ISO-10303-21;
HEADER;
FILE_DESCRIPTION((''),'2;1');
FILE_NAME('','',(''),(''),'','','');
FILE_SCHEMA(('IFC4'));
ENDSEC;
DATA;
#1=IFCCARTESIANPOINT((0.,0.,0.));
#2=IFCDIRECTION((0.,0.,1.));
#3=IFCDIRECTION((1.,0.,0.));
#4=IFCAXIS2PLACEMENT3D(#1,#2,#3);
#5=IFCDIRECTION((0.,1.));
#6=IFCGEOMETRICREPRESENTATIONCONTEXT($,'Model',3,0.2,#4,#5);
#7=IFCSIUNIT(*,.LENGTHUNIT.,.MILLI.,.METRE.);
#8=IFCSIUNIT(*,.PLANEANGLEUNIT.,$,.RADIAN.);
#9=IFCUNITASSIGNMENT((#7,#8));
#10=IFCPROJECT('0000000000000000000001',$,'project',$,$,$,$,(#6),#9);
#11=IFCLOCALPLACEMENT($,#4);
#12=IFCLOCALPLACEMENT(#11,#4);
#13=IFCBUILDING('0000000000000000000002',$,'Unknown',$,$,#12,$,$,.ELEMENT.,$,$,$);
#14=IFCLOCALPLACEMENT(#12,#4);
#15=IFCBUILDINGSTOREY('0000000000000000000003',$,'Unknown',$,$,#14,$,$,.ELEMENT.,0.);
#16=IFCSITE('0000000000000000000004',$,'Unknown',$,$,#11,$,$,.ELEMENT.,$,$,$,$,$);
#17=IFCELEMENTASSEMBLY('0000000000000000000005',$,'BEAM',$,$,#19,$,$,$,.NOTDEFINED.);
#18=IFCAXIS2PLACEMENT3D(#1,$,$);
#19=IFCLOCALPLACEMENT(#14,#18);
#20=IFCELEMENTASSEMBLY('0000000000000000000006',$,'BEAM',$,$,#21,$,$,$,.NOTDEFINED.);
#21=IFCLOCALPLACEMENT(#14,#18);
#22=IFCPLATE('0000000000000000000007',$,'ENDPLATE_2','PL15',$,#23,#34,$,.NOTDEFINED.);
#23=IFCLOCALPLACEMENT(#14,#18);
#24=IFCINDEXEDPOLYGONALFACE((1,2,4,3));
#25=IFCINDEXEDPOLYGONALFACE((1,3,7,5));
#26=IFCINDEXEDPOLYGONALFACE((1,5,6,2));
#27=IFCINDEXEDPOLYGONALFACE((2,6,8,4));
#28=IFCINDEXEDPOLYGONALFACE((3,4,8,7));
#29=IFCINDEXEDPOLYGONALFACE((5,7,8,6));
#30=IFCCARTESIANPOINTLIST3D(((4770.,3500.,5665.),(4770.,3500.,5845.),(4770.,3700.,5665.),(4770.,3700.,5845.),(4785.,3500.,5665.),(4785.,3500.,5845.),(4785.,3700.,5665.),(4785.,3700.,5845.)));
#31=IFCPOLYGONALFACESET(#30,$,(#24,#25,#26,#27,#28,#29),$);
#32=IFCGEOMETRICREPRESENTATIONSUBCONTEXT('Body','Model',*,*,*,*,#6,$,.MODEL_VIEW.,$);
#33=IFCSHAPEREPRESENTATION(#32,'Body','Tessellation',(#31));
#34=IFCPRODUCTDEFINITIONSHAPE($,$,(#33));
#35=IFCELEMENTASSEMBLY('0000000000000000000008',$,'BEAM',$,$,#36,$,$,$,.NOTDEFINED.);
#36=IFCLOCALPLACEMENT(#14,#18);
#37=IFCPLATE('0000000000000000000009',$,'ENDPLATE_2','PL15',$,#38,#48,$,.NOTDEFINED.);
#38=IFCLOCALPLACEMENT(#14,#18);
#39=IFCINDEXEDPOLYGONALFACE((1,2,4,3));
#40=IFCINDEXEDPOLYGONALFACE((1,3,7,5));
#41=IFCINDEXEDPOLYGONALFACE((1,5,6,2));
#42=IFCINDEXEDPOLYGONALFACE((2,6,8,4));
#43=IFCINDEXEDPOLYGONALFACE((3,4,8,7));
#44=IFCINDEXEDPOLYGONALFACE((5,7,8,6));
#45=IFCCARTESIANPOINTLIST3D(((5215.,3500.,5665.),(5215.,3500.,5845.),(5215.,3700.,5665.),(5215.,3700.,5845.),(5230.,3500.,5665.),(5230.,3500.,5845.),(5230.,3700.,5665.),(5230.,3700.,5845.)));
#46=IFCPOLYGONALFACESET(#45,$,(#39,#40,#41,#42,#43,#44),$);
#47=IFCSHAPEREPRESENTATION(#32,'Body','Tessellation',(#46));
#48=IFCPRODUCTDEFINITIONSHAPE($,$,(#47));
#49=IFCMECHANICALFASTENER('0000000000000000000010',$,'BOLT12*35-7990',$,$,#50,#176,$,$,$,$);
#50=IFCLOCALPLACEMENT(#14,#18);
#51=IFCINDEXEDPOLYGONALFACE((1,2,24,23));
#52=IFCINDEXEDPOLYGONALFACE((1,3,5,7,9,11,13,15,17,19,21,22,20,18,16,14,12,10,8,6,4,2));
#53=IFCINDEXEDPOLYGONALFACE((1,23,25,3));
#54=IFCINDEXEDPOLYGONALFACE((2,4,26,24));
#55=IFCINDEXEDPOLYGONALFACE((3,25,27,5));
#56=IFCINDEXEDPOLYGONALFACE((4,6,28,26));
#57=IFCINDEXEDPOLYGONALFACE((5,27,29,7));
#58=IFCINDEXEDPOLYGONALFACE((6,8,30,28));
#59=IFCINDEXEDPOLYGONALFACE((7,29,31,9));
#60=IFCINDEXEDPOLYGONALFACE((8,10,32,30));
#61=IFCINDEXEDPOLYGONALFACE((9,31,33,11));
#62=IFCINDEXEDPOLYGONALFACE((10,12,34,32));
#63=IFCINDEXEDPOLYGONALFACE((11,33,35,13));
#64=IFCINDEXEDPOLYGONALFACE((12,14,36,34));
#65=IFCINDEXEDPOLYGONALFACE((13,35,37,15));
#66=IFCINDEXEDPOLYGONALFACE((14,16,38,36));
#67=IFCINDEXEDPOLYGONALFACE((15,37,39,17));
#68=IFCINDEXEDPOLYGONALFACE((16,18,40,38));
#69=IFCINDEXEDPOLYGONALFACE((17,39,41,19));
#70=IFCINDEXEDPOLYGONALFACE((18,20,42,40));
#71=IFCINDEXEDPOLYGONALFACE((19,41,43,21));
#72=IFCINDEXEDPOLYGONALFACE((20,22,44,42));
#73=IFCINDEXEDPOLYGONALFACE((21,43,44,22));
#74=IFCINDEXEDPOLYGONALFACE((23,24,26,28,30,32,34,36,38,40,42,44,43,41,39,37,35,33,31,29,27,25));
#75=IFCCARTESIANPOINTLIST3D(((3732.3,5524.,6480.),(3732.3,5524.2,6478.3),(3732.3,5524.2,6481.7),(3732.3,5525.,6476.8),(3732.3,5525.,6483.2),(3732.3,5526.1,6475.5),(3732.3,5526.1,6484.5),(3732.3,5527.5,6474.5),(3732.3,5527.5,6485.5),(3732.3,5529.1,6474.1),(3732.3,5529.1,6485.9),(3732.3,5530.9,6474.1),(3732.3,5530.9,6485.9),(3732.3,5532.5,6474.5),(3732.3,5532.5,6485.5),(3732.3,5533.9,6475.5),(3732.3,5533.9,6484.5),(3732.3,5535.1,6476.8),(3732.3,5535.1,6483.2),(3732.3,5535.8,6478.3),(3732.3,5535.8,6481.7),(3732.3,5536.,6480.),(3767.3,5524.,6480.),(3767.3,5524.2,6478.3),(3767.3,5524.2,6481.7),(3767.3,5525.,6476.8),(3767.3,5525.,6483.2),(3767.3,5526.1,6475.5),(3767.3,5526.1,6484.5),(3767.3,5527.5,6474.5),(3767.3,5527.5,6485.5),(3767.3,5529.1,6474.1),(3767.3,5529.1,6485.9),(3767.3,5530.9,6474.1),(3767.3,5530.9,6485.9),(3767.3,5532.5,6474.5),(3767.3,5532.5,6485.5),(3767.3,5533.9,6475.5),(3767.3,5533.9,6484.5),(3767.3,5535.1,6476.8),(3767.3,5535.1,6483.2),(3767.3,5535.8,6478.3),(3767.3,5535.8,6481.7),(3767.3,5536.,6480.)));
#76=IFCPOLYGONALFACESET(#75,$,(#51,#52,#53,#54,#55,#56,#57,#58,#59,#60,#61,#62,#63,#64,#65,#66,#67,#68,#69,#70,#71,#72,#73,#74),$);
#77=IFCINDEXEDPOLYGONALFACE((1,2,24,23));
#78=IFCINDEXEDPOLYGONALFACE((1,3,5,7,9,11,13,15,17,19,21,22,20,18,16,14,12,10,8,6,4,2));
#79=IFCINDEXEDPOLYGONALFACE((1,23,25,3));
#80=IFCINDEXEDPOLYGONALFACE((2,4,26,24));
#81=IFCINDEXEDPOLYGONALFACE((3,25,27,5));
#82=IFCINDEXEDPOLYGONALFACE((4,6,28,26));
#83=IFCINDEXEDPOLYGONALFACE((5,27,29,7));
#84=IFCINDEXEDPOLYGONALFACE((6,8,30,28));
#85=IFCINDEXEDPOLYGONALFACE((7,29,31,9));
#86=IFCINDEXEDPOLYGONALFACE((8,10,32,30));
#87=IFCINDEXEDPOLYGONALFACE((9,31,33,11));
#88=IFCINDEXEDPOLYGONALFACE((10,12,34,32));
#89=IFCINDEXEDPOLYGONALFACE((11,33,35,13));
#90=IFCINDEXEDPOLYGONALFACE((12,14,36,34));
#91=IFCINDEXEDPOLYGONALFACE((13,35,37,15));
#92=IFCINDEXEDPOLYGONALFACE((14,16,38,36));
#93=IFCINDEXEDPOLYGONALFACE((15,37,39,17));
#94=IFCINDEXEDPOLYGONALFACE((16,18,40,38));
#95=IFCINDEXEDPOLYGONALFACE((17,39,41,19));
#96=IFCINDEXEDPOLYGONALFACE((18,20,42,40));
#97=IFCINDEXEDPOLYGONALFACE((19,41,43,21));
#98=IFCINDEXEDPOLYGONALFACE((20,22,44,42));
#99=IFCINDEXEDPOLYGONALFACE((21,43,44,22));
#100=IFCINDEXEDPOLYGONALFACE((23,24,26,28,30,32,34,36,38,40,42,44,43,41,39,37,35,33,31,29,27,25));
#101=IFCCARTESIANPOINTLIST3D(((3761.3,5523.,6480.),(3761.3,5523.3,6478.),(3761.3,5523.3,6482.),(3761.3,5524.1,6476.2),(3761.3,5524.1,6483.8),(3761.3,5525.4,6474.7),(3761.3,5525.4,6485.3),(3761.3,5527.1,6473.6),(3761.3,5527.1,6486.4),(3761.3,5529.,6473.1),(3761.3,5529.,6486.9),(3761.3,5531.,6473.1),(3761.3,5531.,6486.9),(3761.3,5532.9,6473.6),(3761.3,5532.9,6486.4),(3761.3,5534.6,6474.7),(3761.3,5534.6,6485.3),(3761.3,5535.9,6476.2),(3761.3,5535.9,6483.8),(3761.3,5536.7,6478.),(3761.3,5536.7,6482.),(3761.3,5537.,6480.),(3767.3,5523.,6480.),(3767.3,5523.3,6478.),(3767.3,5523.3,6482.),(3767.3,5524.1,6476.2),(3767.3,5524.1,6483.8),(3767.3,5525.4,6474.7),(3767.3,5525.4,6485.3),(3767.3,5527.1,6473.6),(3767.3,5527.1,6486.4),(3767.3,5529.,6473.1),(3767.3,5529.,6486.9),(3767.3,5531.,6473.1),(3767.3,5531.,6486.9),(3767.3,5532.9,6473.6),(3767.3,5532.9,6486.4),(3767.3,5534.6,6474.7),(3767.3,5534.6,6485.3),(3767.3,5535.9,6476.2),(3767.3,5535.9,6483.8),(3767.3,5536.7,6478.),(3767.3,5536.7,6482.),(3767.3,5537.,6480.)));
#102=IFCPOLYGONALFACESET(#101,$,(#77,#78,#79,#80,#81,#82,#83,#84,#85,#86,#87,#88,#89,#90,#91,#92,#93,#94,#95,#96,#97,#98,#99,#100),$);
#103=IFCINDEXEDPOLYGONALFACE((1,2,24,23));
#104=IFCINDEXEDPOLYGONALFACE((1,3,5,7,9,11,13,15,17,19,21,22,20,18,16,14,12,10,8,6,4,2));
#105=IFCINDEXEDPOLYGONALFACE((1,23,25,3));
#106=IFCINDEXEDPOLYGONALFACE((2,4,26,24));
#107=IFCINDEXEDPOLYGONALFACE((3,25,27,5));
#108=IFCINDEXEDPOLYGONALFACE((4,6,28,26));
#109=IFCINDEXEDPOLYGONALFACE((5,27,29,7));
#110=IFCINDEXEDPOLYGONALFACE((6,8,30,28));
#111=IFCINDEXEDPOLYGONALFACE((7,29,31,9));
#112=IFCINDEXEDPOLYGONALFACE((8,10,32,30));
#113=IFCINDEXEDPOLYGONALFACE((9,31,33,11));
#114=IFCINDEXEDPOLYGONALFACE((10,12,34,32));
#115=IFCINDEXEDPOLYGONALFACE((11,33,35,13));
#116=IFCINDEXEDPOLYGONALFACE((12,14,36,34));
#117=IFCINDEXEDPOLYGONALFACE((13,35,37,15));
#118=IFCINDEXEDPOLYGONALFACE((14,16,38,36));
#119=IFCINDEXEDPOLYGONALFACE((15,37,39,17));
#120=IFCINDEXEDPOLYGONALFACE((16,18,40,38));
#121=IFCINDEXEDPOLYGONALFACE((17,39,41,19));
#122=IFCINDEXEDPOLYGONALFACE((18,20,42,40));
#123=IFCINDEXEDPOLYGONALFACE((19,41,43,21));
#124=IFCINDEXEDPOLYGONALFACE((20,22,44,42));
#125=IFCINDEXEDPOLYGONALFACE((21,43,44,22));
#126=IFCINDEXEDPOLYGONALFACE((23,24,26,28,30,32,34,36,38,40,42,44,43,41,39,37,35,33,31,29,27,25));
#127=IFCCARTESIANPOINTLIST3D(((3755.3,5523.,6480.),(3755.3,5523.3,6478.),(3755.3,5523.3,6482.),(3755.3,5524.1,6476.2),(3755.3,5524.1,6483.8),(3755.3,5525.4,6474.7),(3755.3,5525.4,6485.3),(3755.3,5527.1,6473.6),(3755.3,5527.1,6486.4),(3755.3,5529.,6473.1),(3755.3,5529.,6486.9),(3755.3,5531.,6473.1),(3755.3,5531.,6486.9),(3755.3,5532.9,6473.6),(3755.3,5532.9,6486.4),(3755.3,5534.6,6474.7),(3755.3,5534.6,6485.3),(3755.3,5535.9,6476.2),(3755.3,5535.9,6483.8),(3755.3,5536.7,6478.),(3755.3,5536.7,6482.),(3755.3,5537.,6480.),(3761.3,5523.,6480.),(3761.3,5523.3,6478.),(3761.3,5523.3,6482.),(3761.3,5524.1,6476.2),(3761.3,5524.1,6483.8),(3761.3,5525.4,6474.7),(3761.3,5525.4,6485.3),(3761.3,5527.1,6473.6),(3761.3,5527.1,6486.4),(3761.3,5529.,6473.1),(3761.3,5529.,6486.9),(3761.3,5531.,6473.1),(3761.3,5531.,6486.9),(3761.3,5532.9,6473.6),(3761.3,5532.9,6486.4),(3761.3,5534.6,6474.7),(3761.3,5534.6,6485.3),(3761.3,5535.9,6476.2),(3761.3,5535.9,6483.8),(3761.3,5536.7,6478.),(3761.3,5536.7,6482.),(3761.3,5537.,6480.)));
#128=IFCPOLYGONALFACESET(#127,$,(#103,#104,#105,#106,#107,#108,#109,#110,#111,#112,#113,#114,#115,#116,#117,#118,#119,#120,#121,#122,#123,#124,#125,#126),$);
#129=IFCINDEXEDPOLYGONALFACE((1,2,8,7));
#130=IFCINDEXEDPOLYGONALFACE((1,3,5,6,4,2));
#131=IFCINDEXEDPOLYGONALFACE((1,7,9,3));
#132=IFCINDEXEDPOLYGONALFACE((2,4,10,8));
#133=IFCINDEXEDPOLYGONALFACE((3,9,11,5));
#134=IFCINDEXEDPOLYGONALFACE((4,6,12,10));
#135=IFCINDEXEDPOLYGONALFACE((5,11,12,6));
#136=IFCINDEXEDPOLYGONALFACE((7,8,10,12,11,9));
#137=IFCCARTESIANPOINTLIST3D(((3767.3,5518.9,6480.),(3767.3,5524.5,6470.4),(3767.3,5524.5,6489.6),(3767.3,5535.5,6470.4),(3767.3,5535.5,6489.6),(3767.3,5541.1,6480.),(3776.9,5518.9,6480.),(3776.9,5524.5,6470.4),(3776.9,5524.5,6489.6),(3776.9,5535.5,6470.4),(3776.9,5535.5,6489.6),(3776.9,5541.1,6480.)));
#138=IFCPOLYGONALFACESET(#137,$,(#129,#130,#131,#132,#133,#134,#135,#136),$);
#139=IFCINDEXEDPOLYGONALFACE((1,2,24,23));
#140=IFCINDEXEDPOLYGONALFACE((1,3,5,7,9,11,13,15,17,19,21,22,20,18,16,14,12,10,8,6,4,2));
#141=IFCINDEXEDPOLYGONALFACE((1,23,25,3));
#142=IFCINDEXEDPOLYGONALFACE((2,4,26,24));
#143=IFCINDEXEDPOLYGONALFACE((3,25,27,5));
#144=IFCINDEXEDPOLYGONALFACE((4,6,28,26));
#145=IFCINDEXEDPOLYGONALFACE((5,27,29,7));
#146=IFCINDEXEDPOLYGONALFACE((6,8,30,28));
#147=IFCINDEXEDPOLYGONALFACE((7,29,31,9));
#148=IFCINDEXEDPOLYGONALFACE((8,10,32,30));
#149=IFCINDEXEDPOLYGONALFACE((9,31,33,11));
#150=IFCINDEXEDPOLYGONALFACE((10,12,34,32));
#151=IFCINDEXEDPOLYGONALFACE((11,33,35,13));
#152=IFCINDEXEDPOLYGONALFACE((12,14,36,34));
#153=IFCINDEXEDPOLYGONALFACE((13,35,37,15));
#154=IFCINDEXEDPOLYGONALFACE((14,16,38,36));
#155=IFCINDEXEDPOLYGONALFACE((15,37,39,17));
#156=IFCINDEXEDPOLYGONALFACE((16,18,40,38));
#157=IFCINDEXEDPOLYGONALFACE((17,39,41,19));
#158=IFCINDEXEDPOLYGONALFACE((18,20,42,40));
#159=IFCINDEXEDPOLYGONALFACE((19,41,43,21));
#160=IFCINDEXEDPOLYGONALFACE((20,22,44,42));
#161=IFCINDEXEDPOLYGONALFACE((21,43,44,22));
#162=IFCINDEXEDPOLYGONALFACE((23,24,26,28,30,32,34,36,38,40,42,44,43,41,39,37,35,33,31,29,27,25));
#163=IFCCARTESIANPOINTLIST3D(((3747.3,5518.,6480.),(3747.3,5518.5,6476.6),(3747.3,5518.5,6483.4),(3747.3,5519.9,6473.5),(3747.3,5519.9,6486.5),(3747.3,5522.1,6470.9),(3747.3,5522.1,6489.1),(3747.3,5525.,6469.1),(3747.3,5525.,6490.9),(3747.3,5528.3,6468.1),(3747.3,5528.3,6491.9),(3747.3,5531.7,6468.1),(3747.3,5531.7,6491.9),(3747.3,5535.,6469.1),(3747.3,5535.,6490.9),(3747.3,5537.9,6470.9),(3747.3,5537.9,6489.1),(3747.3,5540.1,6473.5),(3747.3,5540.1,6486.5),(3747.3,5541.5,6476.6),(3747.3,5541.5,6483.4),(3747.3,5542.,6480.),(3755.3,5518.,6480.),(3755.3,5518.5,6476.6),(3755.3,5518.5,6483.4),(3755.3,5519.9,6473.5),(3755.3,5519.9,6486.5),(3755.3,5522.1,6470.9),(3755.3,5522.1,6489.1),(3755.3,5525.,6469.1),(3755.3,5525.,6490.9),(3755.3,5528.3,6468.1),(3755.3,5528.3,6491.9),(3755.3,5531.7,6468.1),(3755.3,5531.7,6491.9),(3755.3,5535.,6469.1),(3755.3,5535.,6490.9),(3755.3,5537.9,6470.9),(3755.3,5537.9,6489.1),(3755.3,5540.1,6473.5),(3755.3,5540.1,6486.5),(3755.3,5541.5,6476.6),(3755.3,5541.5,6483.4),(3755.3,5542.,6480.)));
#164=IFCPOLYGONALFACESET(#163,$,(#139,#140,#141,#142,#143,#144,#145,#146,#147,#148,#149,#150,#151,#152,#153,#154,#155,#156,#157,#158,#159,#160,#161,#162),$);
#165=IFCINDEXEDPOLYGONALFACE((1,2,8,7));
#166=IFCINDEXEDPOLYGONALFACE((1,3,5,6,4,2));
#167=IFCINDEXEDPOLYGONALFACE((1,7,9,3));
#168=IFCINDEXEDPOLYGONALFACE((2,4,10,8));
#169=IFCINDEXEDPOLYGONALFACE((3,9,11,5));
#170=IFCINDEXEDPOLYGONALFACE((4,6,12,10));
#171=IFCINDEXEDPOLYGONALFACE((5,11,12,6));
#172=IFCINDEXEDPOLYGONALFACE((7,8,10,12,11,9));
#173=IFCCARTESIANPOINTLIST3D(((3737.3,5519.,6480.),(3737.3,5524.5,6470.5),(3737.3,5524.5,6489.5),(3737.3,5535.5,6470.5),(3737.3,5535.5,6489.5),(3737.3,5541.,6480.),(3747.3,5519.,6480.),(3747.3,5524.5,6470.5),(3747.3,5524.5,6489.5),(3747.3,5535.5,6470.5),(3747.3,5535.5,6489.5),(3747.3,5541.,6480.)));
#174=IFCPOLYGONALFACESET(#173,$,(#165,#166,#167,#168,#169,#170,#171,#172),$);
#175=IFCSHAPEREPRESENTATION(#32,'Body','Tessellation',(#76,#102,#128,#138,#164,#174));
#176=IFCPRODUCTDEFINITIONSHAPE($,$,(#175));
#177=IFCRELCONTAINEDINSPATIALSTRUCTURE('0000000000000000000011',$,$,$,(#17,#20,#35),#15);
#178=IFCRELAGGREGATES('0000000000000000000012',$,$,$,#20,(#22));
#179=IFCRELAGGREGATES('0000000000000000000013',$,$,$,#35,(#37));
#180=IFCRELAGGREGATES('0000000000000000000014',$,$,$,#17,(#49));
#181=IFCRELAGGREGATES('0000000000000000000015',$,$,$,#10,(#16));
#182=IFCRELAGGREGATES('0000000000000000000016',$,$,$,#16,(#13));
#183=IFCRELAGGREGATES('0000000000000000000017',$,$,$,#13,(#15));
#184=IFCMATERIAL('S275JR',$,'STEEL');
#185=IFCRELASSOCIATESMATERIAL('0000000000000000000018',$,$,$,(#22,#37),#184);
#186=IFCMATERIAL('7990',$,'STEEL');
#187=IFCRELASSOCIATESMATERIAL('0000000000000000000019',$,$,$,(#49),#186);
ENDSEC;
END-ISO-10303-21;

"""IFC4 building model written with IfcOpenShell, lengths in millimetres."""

from ifc_helpers import new_model, si_unit, direction, frame, origin_with_axes, place, context, subcontext, project, spatial, line, arc, indexed_curve, outline, extrude, source, transform, mapped, material, element, aggregate, save


model = new_model("IFC4")

# Units and contexts
model_context = context("Model", 3, precision=0.2, world=origin_with_axes(), true_north=direction((0.0, 1.0)))
body_context = subcontext(model_context, "Body", "Model", "MODEL_VIEW")
ifc_project = project(units=[si_unit("LENGTHUNIT", "METRE", prefix="MILLI"), si_unit("PLANEANGLEUNIT", "RADIAN")], contexts=[model_context])

# Site, building, storey
site_placement = place(None, origin_with_axes())
site = spatial("IfcSite", under=ifc_project, at=site_placement, Name="Unknown", CompositionType="ELEMENT")
building_placement = place(site_placement, origin_with_axes())
building = spatial("IfcBuilding", under=site, at=building_placement, Name="Unknown", CompositionType="ELEMENT")
storey_placement = place(building_placement, origin_with_axes())
storey = spatial("IfcBuildingStorey", under=building, at=storey_placement, Name="Unknown", CompositionType="ELEMENT", Elevation=0.0)

# Element assembly
assembly_1_placement = place(storey_placement, frame((3776.3, 5500.0, 6980.0), z_axis=(-1.0, 0.0, 0.0), x_axis=(0.0, -1.0, 0.000002)))
assembly_1 = element("IfcElementAssembly", 1, at=assembly_1_placement, inside=storey, Name="BEAM", PredefinedType="NOTDEFINED")
ifc_material_1 = material(Name="S275JR", Category="STEEL")

# Element assembly
assembly_2_placement = place(storey_placement, frame((600.0, 3600.0, 5755.0), z_axis=(-0.000002, -1.0, 0.0), x_axis=(1.0, 0.0, 0.0)))
assembly_2 = element("IfcElementAssembly", 2, at=assembly_2_placement, inside=storey, Name="BEAM", PredefinedType="NOTDEFINED")

# Plate
plate_1_placement = place(assembly_2_placement, frame((4177.5, -90.0, 100.0), z_axis=(-1.0, 0.0, 0.0), x_axis=(0.0, 1.0, 0.0)))
plate_1 = element("IfcPlate", 3, at=plate_1_placement, material=ifc_material_1, Name="ENDPLATE_2", Description="PL15", PredefinedType="NOTDEFINED", context=body_context, shape_type="SolidModel", body=[
    extrude(outline(indexed_curve([(0.0, 0.0), (180.0, 0.0), (180.0, 200.0), (0.0, 200.0)], segments=[line(1, 2, 3, 4, 1)])), frame((0.0, 0.0, 7.5), z_axis=(0.0, 0.0, 1.0), x_axis=(1.0, 0.0, 0.0)), (0.0, -0.000002, -1.0), 15.0),
])
aggregate(assembly_2, [plate_1])

# Element assembly, plate
assembly_3_placement = place(storey_placement, frame((5000.0, 3600.0, 5755.0), z_axis=(-0.000002, -1.0, 0.0), x_axis=(1.0, 0.0, 0.0)))
assembly_3 = element("IfcElementAssembly", 4, at=assembly_3_placement, inside=storey, Name="BEAM", PredefinedType="NOTDEFINED")
plate_2_placement = place(assembly_3_placement, frame((222.5, -90.0, -100.0), z_axis=(1.0, 0.0, 0.0), x_axis=(0.0, 1.0, 0.0)))
plate_2 = element("IfcPlate", 5, at=plate_2_placement, material=ifc_material_1, Name="ENDPLATE_2", Description="PL15", PredefinedType="NOTDEFINED", context=body_context, shape_type="SolidModel", body=[
    extrude(outline(indexed_curve([(0.0, 0.0), (180.0, 0.0), (180.0, 200.0), (0.0, 200.0)], segments=[line(1, 2, 3, 4, 1)])), frame((0.0, 0.0, 7.5), z_axis=(0.0, 0.0, 1.0), x_axis=(1.0, 0.0, 0.0)), (0.0, -0.000002, -1.0), 15.0),
])
aggregate(assembly_3, [plate_2])

# Mechanical fastener
ifc_material_2 = material(Name="7990", Category="STEEL")
shared_shape_1 = source(origin_with_axes(), body_context, "Body", "SweptSolid", [
    extrude(outline(indexed_curve([(6.0, 0.0), (0.0, 6.0), (-6.0, 0.0), (0.0, -6.0)], segments=[arc(1, 2, 3), arc(3, 4, 1)])), frame((0.0, 0.0, 6.0), z_axis=(0.0, -0.000002, -1.0), x_axis=(0.0, 1.0, 0.0)), (0.0, 0.0, 1.0), 35.0),
    extrude(outline(indexed_curve([(7.0, 0.0), (0.0, 7.0), (-7.0, 0.0), (0.0, -7.0)], segments=[arc(1, 2, 3), arc(3, 4, 1)])), frame((0.0, 0.0, 6.0), z_axis=(0.0, -0.000002, -1.0), x_axis=(0.0, 1.0, 0.0)), (0.0, 0.0, 1.0), 6.0),
    extrude(outline(indexed_curve([(7.0, 0.0), (0.0, 7.0), (-7.0, 0.0), (0.0, -7.0)], segments=[arc(1, 2, 3), arc(3, 4, 1)])), frame((0.0, 0.0, 0.0), z_axis=(0.0, -0.000002, -1.0), x_axis=(0.0, 1.0, 0.0)), (0.0, 0.0, 1.0), 6.0),
    extrude(outline(indexed_curve([(11.1, 0.0), (5.5, 9.6), (-5.5, 9.6), (-11.1, 0.0), (-5.5, -9.6), (5.5, -9.6)], segments=[line(1, 2, 3, 4, 5, 6, 1)])), frame((0.0, 0.0, 15.6), z_axis=(0.0, -0.000002, -1.0), x_axis=(0.0, 1.0, 0.0)), (0.0, 0.0, 1.0), 9.6),
    extrude(outline(indexed_curve([(12.0, 0.0), (0.0, 12.0), (-12.0, 0.0), (0.0, -12.0)], segments=[arc(1, 2, 3), arc(3, 4, 1)])), frame((0.0, 0.0, -6.0), z_axis=(0.0, -0.000002, -1.0), x_axis=(0.0, 1.0, 0.0)), (0.0, 0.0, 1.0), 8.0),
    extrude(outline(indexed_curve([(11.0, 0.0), (5.5, 9.5), (-5.5, 9.5), (-11.0, 0.0), (-5.5, -9.5), (5.5, -9.5)], segments=[line(1, 2, 3, 4, 5, 6, 1)])), frame((0.0, 0.0, -14.0), z_axis=(0.0, -0.000002, -1.0), x_axis=(0.0, 1.0, 0.0)), (0.0, 0.0, 1.0), 10.0),
])
mechanical_fastener_1_placement = place(assembly_1_placement, frame((-30.0, -500.0, 15.0), z_axis=(0.0, -0.000002, -1.0), x_axis=(0.0, -1.0, 0.000002)))
mechanical_fastener_1 = element("IfcMechanicalFastener", 6, at=mechanical_fastener_1_placement, material=ifc_material_2, Name="BOLT12*35-7990", context=body_context, shape_type="MappedRepresentation", body=[
    mapped(shared_shape_1, transform((0.0, 0.0, 0.0))),
])
aggregate(assembly_1, [mechanical_fastener_1])

save(model, "model.ifc")
